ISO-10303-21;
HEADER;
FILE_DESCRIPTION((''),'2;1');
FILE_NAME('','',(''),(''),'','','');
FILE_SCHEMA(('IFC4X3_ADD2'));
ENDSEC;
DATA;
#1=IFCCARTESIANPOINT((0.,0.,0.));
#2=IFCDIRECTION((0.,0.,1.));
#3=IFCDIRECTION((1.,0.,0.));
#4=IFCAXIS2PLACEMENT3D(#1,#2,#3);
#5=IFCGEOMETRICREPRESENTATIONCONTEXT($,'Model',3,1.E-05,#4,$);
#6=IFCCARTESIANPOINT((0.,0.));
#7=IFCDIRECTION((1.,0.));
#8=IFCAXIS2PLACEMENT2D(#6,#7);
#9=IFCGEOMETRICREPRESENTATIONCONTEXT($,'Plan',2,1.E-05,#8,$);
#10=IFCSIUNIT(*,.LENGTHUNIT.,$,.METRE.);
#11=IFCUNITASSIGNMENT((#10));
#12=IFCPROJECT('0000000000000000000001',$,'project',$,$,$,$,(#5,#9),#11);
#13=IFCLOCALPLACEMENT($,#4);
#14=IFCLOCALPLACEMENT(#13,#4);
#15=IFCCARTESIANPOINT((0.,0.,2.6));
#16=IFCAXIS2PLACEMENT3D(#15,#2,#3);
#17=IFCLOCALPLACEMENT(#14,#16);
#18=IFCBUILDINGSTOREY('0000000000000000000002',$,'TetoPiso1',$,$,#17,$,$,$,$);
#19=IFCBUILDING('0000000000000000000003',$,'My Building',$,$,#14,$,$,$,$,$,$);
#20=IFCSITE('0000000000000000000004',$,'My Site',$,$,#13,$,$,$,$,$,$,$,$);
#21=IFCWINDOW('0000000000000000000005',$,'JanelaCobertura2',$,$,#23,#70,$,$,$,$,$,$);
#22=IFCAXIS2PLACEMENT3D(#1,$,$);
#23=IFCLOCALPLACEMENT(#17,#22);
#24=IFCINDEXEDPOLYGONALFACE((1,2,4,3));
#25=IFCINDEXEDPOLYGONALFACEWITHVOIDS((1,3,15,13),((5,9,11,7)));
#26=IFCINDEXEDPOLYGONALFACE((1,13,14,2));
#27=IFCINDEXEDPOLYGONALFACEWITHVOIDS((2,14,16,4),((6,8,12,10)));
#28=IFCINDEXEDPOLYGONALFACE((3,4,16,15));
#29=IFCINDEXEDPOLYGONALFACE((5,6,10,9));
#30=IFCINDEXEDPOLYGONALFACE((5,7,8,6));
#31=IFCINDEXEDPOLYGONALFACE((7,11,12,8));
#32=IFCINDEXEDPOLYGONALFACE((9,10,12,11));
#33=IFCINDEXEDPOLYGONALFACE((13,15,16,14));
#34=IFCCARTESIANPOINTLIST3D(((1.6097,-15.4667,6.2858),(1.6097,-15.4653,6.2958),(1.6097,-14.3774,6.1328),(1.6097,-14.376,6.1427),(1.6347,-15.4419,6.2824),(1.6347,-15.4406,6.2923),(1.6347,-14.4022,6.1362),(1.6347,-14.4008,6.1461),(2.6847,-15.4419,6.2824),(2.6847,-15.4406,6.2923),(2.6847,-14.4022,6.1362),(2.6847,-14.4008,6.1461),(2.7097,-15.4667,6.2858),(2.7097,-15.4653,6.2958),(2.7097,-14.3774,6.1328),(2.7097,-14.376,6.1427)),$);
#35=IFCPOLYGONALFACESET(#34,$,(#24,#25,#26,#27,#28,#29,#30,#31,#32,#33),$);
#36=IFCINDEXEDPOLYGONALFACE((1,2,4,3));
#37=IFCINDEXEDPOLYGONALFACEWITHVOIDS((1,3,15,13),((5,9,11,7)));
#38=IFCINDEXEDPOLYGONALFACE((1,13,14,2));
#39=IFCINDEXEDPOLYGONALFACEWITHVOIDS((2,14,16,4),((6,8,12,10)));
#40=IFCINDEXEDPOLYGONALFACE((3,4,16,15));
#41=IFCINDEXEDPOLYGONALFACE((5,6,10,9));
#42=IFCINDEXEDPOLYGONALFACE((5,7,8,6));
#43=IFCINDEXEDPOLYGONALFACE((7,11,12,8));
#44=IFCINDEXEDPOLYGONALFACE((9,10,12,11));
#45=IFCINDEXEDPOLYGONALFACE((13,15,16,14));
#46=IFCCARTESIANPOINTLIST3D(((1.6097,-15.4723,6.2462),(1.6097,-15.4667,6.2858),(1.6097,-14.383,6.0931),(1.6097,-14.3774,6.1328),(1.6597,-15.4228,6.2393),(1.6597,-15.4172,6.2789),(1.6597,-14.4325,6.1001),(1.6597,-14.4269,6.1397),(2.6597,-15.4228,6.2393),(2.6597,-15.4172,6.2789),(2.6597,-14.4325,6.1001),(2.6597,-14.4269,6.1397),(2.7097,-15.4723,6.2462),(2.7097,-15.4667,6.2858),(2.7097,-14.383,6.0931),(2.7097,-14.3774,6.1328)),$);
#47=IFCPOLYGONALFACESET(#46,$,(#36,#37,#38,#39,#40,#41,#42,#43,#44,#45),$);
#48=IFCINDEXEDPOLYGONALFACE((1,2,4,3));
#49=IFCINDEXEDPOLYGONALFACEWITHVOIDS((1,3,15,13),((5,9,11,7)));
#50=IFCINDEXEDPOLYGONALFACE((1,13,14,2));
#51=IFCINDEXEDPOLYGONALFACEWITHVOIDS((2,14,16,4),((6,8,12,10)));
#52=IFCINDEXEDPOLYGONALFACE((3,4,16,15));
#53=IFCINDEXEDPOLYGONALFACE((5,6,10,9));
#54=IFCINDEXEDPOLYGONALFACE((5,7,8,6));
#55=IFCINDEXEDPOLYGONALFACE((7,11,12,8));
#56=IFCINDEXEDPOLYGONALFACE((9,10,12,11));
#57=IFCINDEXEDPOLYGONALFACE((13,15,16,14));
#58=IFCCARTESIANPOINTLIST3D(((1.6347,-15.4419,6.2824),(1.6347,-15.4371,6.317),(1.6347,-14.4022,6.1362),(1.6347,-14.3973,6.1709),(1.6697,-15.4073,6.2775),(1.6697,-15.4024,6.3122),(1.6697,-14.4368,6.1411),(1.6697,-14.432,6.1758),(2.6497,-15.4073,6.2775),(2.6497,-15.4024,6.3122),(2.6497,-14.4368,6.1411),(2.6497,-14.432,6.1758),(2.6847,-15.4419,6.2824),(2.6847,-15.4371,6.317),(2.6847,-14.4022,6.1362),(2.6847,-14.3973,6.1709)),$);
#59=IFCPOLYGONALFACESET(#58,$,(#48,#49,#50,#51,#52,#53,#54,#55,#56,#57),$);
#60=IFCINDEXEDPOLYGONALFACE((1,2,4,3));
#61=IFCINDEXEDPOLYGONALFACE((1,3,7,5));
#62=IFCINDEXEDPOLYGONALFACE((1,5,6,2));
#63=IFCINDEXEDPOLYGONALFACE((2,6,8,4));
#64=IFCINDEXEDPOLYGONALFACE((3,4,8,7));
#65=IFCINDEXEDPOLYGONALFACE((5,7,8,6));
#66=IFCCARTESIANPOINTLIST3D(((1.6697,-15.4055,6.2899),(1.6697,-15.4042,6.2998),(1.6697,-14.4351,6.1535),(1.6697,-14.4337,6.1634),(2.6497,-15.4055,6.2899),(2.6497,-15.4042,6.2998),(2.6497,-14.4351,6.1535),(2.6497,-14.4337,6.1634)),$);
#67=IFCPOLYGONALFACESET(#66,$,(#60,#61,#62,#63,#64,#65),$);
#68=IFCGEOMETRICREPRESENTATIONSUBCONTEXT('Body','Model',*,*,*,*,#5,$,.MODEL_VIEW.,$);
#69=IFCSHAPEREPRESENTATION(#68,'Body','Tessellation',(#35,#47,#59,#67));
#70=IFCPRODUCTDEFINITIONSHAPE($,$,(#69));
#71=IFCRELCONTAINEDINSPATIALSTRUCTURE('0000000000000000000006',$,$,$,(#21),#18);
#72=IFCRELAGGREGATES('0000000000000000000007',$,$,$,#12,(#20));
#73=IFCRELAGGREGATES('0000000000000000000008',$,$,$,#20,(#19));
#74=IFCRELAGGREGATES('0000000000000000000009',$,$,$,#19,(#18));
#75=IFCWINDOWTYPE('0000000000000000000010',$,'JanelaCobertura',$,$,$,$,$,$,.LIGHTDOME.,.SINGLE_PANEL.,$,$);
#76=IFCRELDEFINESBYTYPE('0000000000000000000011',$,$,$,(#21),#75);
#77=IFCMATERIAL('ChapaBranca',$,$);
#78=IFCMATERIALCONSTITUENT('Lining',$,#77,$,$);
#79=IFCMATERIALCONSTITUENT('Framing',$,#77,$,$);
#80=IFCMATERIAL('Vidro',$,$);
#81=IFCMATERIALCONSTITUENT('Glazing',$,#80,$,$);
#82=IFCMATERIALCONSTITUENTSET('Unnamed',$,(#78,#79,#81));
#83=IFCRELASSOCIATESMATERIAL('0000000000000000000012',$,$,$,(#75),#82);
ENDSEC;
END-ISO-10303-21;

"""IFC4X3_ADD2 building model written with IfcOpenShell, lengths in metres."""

from ifc_helpers import new_model, entity, si_unit, frame, origin_with_axes, origin_2d_with_axis, place, context, subcontext, project, spatial, line, indexed_curve, outline, extrude, shape, source, transform, mapped, material, constituent, constituent_set, type_object, type_shapes, element, save


model = new_model("IFC4X3_ADD2")

# Units and contexts
model_context = context("Model", 3, precision=1e-05, world=origin_with_axes())
plan_context = context("Plan", 2, precision=1e-05, world=origin_2d_with_axis())
body_context_1 = subcontext(model_context, "Body", "Model", "MODEL_VIEW")
body_context_2 = subcontext(plan_context, "Body", "Plan", "PLAN_VIEW")
ifc_project = project(units=[si_unit("LENGTHUNIT", "METRE")], contexts=[model_context, plan_context])

# Site, building, storey
site_placement = place(None, origin_with_axes())
site = spatial("IfcSite", under=ifc_project, at=site_placement, Name="My Site")
building_placement = place(site_placement, origin_with_axes())
building = spatial("IfcBuilding", under=site, at=building_placement, Name="My Building")
storey_placement = place(building_placement, frame((0.0, 0.0, 2.6), z_axis=(0.0, 0.0, 1.0), x_axis=(1.0, 0.0, 0.0)))
storey = spatial("IfcBuildingStorey", under=building, at=storey_placement, Name="TetoPiso1")

# Shared definitions
ifc_material_1 = material(Name="ChapaBranca")

# Window
ifc_constituent_1 = constituent(ifc_material_1, Name="Lining")
ifc_constituent_2 = constituent(ifc_material_1, Name="Framing")
ifc_material_2 = material(Name="Vidro")
ifc_constituent_3 = constituent(ifc_material_2, Name="Glazing")
ifc_constituent_set = constituent_set(constituents=[ifc_constituent_1, ifc_constituent_2, ifc_constituent_3], Name="Unnamed")
window_type = type_object("IfcWindowType", Name="JanelaCobertura", PartitioningType="SINGLE_PANEL", PredefinedType="LIGHTDOME", material=ifc_constituent_set)
shared_shape_1 = source(origin_with_axes(), body_context_1, "Body", "SweptSolid", [
    extrude(outline(indexed_curve([(0.0, 0.0), (1.1, 0.0), (1.1, 1.1), (0.0, 1.1)], segments=[line(1, 2, 3, 4, 1)]), holes=[indexed_curve([(0.025, 0.025), (1.075, 0.025), (1.075, 1.075), (0.025, 1.075)], segments=[line(1, 2, 3, 4, 1)])]), frame((0.0, 0.09, 0.0), z_axis=(0.0, -1.0, 0.0), x_axis=(1.0, 0.0, 0.0)), (0.0, 0.0, -1.0), 0.01),
    extrude(outline(indexed_curve([(0.0, 0.0), (1.1, 0.0), (1.1, 1.1), (0.0, 1.1)], segments=[line(1, 2, 3, 4, 1)]), holes=[indexed_curve([(0.05, 0.05), (1.05, 0.05), (1.05, 1.05), (0.05, 1.05)], segments=[line(1, 2, 3, 4, 1)])]), frame((0.0, 0.05, 0.0), z_axis=(0.0, -1.0, 0.0), x_axis=(1.0, 0.0, 0.0)), (0.0, 0.0, -1.0), 0.04),
    extrude(outline(indexed_curve([(0.0, 0.0), (1.05, 0.0), (1.05, 1.05), (0.0, 1.05)], segments=[line(1, 2, 3, 4, 1)]), holes=[indexed_curve([(0.035, 0.035), (1.015, 0.035), (1.015, 1.015), (0.035, 1.015)], segments=[line(1, 2, 3, 4, 1)])]), frame((0.025, 0.09, 0.025), z_axis=(0.0, -1.0, 0.0), x_axis=(1.0, 0.0, 0.0)), (0.0, 0.0, -1.0), 0.035),
    extrude(outline(indexed_curve([(0.035, 0.035), (1.015, 0.035), (1.015, 1.015), (0.035, 1.015)], segments=[line(1, 2, 3, 4, 1)])), frame((0.025, 0.1025, 0.025), z_axis=(0.0, -1.0, 0.0), x_axis=(1.0, 0.0, 0.0)), (0.0, 0.0, -1.0), 0.01),
])
shared_shape_2 = source(origin_with_axes(), body_context_2, "Body", "Curve2D", [
    entity("IfcIndexedPolyCurve", entity("IfcCartesianPointList2D", [[0.05, 0.05], [1.05, 0.05]])),
    entity("IfcIndexedPolyCurve", entity("IfcCartesianPointList2D", [[0.0, 0.1], [0.025, 0.1], [0.025, 0.09], [0.05, 0.09], [0.05, 0.05], [0.0, 0.05]]), [entity("IfcLineIndex", [1, 2, 3, 4, 5, 6, 1])]),
    entity("IfcIndexedPolyCurve", entity("IfcCartesianPointList2D", [[1.1, 0.1], [1.075, 0.1], [1.075, 0.09], [1.05, 0.09], [1.05, 0.05], [1.1, 0.05]]), [entity("IfcLineIndex", [1, 2, 3, 4, 5, 6, 1])]),
    entity("IfcIndexedPolyCurve", entity("IfcCartesianPointList2D", [[0.025, 0.09], [0.06, 0.09], [0.06, 0.125], [0.025, 0.125]]), [entity("IfcLineIndex", [1, 2, 3, 4, 1])]),
    entity("IfcIndexedPolyCurve", entity("IfcCartesianPointList2D", [[1.075, 0.09], [1.04, 0.09], [1.04, 0.125], [1.075, 0.125]]), [entity("IfcLineIndex", [1, 2, 3, 4, 1])]),
    entity("IfcIndexedPolyCurve", entity("IfcCartesianPointList2D", [[0.06, 0.09], [1.04, 0.09]])),
    entity("IfcIndexedPolyCurve", entity("IfcCartesianPointList2D", [[0.06, 0.125], [1.04, 0.125]])),
    entity("IfcIndexedPolyCurve", entity("IfcCartesianPointList2D", [[0.06, 0.1075], [1.04, 0.1075]])),
])
type_shapes(window_type, [shared_shape_1, shared_shape_2])
window_1_placement = place(storey_placement, frame((2.7097, -15.4792, 6.1967), z_axis=(0.0, 0.990268, -0.139173), x_axis=(-1.0, 0.0, 0.0)))
element("IfcWindow", 1, at=window_1_placement, inside=storey, type_object=window_type, Name="JanelaCobertura2", shapes=[
    shape(body_context_1, "Body", "MappedRepresentation", [mapped(shared_shape_1, transform((0.0, 0.0, 0.0), x_axis=(1.0, 0.0, 0.0), y_axis=(0.0, 1.0, 0.0), z_axis=(0.0, 0.0, 1.0), scale=1.0))]),
    shape(body_context_2, "Body", "MappedRepresentation", [mapped(shared_shape_2, transform((0.0, 0.0, 0.0), x_axis=(1.0, 0.0, 0.0), y_axis=(0.0, 1.0, 0.0), z_axis=(0.0, 0.0, 1.0), scale=1.0))]),
])

save(model, "model.ifc")
